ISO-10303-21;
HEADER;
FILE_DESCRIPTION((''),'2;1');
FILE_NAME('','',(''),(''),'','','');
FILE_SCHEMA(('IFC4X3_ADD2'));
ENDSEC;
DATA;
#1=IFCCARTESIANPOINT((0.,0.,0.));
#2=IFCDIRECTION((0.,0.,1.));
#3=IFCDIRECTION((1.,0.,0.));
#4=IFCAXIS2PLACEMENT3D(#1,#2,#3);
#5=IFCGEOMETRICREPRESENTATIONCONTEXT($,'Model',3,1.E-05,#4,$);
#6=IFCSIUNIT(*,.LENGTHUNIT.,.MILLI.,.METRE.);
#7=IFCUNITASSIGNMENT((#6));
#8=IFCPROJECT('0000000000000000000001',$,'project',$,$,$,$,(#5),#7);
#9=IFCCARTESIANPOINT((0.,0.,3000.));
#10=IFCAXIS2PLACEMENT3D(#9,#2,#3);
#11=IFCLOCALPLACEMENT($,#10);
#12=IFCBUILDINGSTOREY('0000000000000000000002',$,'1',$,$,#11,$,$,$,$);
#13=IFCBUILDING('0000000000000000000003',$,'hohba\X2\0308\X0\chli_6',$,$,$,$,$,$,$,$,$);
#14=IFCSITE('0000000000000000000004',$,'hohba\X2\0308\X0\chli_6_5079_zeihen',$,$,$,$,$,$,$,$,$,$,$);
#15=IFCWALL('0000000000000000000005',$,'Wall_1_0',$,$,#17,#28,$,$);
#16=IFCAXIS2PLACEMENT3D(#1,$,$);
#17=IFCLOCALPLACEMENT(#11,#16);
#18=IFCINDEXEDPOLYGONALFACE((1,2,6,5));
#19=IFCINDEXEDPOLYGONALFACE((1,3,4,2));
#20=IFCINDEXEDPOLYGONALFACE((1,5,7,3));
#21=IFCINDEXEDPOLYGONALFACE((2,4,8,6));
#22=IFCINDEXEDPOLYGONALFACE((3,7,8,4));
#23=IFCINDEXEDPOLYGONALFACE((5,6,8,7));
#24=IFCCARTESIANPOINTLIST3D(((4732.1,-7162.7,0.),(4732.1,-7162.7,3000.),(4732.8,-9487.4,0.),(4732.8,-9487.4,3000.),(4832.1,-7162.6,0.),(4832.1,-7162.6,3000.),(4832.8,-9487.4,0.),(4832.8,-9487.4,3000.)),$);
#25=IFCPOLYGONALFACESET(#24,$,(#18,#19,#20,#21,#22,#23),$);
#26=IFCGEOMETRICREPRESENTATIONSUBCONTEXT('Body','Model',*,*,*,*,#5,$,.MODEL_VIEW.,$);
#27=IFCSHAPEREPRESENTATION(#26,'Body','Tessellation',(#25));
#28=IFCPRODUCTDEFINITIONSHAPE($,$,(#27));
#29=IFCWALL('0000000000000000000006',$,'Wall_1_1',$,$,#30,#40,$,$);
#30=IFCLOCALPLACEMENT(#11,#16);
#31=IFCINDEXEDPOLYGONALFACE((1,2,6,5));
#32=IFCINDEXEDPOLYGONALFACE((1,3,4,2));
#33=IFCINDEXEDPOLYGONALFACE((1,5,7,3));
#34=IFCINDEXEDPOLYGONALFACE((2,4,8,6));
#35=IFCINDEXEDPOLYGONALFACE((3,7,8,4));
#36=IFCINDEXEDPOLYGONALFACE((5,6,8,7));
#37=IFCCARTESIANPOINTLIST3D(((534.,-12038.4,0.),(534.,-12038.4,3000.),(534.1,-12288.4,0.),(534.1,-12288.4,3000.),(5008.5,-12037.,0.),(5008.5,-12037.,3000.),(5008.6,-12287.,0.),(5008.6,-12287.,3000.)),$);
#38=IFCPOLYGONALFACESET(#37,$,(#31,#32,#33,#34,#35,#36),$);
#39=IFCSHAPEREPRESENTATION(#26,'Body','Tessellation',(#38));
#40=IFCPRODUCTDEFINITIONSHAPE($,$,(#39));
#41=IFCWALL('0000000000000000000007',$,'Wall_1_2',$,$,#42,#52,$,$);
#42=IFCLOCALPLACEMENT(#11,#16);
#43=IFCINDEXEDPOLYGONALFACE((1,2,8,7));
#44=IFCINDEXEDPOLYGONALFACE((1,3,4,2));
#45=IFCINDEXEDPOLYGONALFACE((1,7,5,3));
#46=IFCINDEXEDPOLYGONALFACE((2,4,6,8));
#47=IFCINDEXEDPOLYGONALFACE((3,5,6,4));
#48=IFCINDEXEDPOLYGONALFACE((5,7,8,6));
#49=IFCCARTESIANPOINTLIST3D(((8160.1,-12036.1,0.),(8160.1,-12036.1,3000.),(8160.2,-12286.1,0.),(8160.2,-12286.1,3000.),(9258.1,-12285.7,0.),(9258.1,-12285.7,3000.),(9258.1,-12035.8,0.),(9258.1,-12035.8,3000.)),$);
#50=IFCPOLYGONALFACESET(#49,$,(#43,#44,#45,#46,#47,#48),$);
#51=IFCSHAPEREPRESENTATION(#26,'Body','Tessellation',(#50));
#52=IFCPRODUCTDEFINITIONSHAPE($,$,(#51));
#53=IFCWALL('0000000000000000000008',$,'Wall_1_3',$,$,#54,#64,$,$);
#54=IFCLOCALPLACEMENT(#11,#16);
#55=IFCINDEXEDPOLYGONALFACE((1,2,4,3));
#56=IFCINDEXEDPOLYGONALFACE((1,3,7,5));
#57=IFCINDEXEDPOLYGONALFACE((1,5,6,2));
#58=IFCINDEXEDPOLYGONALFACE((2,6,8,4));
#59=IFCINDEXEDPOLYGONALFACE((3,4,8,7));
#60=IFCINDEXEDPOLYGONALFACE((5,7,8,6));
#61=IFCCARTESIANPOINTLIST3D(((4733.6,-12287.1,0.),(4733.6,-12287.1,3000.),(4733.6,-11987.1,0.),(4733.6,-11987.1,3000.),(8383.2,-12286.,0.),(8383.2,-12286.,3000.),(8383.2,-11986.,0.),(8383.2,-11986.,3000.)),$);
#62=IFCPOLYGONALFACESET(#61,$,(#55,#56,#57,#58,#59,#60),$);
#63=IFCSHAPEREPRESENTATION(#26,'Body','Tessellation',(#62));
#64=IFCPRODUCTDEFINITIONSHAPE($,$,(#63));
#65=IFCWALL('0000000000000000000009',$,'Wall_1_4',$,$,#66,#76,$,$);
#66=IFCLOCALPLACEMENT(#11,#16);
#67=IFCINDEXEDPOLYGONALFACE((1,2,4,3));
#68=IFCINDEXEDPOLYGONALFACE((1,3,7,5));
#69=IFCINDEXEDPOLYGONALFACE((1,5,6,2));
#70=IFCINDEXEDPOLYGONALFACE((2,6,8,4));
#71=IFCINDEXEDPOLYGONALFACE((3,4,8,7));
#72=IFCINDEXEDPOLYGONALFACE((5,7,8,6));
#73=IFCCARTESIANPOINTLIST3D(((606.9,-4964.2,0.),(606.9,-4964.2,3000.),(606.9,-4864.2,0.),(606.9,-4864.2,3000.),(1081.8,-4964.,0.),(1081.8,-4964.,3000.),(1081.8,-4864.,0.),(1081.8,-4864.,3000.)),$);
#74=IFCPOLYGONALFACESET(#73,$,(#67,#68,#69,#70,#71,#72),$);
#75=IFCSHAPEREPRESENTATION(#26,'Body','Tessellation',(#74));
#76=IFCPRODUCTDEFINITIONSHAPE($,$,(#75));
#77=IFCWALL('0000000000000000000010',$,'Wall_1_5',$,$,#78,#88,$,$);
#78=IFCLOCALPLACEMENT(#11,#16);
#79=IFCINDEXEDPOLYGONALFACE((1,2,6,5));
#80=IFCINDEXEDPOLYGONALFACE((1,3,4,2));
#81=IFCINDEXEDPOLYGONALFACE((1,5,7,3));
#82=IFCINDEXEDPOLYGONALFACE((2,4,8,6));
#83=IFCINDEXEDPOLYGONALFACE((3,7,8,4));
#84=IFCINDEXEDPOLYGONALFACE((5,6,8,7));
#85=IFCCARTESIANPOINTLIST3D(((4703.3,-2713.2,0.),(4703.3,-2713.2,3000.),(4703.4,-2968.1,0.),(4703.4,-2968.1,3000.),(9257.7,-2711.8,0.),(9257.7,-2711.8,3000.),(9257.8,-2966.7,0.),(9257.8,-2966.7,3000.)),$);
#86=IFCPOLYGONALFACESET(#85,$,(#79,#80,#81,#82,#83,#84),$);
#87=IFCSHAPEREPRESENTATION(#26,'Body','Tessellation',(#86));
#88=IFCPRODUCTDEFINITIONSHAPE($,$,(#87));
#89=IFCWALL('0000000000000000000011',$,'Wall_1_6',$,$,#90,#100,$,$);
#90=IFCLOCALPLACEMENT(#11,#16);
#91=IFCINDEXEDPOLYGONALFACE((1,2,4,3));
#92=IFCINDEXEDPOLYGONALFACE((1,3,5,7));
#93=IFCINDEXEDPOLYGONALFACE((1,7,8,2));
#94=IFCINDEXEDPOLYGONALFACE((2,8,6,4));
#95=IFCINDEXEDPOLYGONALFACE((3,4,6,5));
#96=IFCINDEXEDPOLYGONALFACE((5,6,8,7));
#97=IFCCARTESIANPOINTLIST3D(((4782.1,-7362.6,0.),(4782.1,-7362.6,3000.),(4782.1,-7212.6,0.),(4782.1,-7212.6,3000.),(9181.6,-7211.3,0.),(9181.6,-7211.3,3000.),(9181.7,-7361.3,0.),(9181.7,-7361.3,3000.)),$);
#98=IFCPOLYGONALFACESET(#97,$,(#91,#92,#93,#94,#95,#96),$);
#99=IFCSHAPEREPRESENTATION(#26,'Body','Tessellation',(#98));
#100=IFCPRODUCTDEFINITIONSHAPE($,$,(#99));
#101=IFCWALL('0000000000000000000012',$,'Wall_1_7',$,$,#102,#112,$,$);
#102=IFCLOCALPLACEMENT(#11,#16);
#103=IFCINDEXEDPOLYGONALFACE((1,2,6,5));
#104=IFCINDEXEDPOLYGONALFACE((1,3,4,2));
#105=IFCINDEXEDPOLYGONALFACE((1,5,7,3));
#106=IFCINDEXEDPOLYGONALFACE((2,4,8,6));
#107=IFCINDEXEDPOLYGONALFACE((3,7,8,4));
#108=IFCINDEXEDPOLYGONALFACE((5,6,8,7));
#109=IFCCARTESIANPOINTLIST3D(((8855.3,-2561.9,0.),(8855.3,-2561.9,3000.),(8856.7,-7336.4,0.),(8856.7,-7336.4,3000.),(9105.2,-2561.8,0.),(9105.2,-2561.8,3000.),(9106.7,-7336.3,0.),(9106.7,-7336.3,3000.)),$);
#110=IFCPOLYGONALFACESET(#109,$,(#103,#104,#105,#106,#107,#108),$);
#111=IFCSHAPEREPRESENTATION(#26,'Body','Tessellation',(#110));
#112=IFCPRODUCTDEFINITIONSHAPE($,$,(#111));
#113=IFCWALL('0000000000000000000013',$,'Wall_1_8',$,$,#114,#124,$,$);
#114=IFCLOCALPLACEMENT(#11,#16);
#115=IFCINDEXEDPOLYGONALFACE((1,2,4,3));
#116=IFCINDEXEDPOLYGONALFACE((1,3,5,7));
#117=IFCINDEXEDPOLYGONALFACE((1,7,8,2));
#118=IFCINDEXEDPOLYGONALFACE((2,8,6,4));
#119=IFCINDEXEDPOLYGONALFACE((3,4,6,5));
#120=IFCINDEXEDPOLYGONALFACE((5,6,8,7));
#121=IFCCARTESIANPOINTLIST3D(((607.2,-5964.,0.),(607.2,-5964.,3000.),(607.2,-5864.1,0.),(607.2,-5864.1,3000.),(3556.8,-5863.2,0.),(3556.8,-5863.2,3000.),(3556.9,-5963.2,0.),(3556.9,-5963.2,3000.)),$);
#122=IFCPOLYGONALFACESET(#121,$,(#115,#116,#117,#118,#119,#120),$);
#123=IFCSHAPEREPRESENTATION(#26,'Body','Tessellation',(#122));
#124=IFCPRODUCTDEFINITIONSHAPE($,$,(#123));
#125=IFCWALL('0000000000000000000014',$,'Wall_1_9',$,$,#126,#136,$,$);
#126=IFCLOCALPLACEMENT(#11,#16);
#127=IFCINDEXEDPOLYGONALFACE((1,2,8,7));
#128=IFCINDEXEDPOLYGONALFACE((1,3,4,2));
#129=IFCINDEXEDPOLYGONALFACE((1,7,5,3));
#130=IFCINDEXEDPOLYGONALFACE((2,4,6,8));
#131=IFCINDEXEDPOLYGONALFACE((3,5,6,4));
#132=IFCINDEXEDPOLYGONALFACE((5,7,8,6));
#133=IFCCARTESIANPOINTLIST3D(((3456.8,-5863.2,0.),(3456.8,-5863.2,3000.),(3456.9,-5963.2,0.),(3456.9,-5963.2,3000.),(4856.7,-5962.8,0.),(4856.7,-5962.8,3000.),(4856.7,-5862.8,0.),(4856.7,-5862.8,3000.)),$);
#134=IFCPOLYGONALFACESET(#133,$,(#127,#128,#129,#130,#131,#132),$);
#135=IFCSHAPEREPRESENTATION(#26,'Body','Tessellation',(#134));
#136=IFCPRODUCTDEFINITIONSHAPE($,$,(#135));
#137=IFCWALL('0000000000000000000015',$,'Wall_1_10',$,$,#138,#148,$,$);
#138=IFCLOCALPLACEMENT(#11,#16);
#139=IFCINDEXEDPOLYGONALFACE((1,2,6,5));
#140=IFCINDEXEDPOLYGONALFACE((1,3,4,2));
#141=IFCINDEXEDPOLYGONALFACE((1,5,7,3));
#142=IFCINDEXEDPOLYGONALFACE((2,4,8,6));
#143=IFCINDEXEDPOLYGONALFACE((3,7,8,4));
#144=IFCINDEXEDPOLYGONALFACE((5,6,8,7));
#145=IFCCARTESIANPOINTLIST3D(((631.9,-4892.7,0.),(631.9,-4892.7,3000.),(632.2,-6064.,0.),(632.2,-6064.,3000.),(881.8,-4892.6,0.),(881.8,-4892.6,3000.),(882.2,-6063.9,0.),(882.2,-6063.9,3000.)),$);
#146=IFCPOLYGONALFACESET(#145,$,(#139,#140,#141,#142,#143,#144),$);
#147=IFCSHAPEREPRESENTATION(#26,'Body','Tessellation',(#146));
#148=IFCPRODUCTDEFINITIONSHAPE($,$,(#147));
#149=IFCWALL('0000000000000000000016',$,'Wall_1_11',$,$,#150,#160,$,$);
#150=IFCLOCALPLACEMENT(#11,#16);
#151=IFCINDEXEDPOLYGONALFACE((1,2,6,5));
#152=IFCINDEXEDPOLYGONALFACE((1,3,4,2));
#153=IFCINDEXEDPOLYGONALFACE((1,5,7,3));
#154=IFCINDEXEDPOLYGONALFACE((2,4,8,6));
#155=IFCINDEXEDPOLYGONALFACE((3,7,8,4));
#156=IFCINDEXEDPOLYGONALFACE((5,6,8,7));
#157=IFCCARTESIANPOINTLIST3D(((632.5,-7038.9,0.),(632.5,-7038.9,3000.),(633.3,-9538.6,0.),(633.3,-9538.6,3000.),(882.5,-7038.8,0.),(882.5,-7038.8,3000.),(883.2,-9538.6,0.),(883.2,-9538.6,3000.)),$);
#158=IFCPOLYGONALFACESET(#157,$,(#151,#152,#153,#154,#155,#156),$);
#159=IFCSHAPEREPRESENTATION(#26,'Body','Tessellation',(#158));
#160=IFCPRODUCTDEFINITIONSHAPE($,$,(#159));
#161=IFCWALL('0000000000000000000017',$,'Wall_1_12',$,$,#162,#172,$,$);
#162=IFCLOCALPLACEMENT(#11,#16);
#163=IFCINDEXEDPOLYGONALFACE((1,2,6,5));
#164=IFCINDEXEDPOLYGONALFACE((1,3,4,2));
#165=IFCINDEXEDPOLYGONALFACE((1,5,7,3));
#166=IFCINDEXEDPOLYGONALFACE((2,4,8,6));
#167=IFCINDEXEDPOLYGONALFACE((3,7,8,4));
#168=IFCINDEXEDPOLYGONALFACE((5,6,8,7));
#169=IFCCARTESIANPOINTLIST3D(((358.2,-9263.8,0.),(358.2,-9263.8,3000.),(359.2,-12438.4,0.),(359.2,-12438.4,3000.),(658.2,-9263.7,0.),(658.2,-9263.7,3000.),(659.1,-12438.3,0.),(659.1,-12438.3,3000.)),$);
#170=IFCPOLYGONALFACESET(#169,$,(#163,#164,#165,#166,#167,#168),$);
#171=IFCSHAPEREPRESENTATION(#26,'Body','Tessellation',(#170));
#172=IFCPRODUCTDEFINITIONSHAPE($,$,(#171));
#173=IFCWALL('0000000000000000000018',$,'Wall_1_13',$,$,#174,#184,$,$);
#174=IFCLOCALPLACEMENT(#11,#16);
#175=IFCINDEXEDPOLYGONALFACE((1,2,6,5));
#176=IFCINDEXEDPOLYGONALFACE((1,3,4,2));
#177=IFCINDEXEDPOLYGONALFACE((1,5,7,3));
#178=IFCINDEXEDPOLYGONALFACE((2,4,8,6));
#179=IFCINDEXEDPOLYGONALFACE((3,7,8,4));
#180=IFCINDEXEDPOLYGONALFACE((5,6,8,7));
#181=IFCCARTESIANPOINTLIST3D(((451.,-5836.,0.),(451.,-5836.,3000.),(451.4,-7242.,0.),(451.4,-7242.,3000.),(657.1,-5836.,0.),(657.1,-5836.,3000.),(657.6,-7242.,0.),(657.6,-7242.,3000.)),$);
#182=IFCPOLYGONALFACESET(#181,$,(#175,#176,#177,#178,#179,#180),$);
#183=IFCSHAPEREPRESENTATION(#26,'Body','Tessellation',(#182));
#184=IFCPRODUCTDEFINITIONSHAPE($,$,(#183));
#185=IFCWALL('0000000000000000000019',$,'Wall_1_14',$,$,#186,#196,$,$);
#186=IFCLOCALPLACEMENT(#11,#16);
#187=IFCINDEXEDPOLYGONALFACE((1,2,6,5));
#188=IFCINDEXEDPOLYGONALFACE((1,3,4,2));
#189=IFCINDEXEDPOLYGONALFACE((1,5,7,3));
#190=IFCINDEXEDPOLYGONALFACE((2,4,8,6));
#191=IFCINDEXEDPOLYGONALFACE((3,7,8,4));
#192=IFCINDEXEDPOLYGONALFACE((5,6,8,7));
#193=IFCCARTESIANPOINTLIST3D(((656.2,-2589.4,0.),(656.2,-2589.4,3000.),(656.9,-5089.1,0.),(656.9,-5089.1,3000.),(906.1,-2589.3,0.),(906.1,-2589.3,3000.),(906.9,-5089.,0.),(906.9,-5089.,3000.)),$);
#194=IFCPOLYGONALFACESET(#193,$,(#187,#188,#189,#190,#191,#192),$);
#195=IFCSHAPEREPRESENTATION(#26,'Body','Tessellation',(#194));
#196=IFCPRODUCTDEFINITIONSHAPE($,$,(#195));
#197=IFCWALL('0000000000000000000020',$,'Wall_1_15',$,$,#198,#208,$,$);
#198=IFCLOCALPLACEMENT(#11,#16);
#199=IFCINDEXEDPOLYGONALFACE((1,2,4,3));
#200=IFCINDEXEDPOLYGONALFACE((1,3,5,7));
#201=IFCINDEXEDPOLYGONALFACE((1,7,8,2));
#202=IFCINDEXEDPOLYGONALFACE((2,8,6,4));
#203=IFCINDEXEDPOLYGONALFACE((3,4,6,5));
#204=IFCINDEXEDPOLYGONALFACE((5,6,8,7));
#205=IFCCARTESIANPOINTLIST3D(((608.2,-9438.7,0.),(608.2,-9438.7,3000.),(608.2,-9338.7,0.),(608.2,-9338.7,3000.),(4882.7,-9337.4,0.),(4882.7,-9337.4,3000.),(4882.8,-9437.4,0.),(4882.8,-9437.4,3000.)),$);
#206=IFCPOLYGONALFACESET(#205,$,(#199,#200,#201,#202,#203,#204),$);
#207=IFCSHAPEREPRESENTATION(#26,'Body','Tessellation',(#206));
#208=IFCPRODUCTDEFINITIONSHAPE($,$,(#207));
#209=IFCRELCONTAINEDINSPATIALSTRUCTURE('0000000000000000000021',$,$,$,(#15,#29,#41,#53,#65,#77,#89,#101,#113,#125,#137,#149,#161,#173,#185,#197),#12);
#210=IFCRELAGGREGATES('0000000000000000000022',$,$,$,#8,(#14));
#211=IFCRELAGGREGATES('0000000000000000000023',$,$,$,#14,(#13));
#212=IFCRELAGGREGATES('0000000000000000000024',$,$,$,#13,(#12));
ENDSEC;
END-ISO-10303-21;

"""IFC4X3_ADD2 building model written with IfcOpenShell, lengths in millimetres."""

from ifc_helpers import new_model, si_unit, frame, origin_with_axes, place, context, subcontext, project, spatial, indexed_curve, outline, extrude, element, save


model = new_model("IFC4X3_ADD2")

# Units and contexts
model_context = context("Model", 3, precision=1e-05, world=origin_with_axes())
body_context = subcontext(model_context, "Body", "Model", "MODEL_VIEW")
ifc_project = project(units=[si_unit("LENGTHUNIT", "METRE", prefix="MILLI")], contexts=[model_context])

# Site, building, storey
site = spatial("IfcSite", under=ifc_project, Name="hohbächli_6_5079_zeihen")
building = spatial("IfcBuilding", under=site, Name="hohbächli_6")
storey_placement = place(None, frame((0.0, 0.0, 3000.0), z_axis=(0.0, 0.0, 1.0), x_axis=(1.0, 0.0, 0.0)))
storey = spatial("IfcBuildingStorey", under=building, at=storey_placement, Name="1")

# Walls
wall_1_placement = place(storey_placement, frame((4832.8, -9487.4, 0.0), z_axis=(0.0, 0.0, 1.0), x_axis=(-0.000302, 1.0, 0.0)))
element("IfcWall", 1, at=wall_1_placement, inside=storey, Name="Wall_1_0", context=body_context, shape_type="SweptSolid", body=[
    extrude(outline(indexed_curve([(0.0, 0.0), (0.0, 100.0), (2324.7, 100.0), (2324.7, 0.0), (0.0, 0.0)], self_intersect=False)), origin_with_axes(), (0.0, 0.0, 1.0), 3000.0),
])
wall_2_placement = place(storey_placement, frame((534.1, -12288.4, 0.0), z_axis=(0.0, 0.0, 1.0), x_axis=(1.0, 0.000302, 0.0)))
element("IfcWall", 2, at=wall_2_placement, inside=storey, Name="Wall_1_1", context=body_context, shape_type="SweptSolid", body=[
    extrude(outline(indexed_curve([(0.0, 0.0), (0.0, 250.0), (4474.5, 250.0), (4474.5, 0.0), (0.0, 0.0)], self_intersect=False)), origin_with_axes(), (0.0, 0.0, 1.0), 3000.0),
])
wall_3_placement = place(storey_placement, frame((8160.2, -12286.1, 0.0), z_axis=(0.0, 0.0, 1.0), x_axis=(1.0, 0.000302, 0.0)))
element("IfcWall", 3, at=wall_3_placement, inside=storey, Name="Wall_1_2", context=body_context, shape_type="SweptSolid", body=[
    extrude(outline(indexed_curve([(0.0, 0.0), (0.0, 250.0), (1098.0, 250.0), (1098.0, 0.0), (0.0, 0.0)], self_intersect=False)), origin_with_axes(), (0.0, 0.0, 1.0), 3000.0),
])
wall_4_placement = place(storey_placement, frame((4733.6, -12287.1, 0.0), z_axis=(0.0, 0.0, 1.0), x_axis=(1.0, 0.000302, 0.0)))
element("IfcWall", 4, at=wall_4_placement, inside=storey, Name="Wall_1_3", context=body_context, shape_type="SweptSolid", body=[
    extrude(outline(indexed_curve([(0.0, 0.0), (0.0, 300.0), (3649.6, 300.0), (3649.6, 0.0), (0.0, 0.0)], self_intersect=False)), origin_with_axes(), (0.0, 0.0, 1.0), 3000.0),
])
wall_5_placement = place(storey_placement, frame((606.9, -4964.2, 0.0), z_axis=(0.0, 0.0, 1.0), x_axis=(1.0, 0.000302, 0.0)))
element("IfcWall", 5, at=wall_5_placement, inside=storey, Name="Wall_1_4", context=body_context, shape_type="SweptSolid", body=[
    extrude(outline(indexed_curve([(0.0, 0.0), (0.0, 100.0), (474.9, 100.0), (474.9, 0.0), (0.0, 0.0)], self_intersect=False)), origin_with_axes(), (0.0, 0.0, 1.0), 3000.0),
])
wall_6_placement = place(storey_placement, frame((9257.7, -2711.8, 0.0), z_axis=(0.0, 0.0, 1.0), x_axis=(-1.0, -0.000302, 0.0)))
element("IfcWall", 6, at=wall_6_placement, inside=storey, Name="Wall_1_5", context=body_context, shape_type="SweptSolid", body=[
    extrude(outline(indexed_curve([(0.0, 0.0), (0.0, 254.9), (4554.5, 254.9), (4554.5, 0.0), (0.0, 0.0)], self_intersect=False)), origin_with_axes(), (0.0, 0.0, 1.0), 3000.0),
])
wall_7_placement = place(storey_placement, frame((9181.6, -7211.3, 0.0), z_axis=(0.0, 0.0, 1.0), x_axis=(-1.0, -0.000302, 0.0)))
element("IfcWall", 7, at=wall_7_placement, inside=storey, Name="Wall_1_6", context=body_context, shape_type="SweptSolid", body=[
    extrude(outline(indexed_curve([(0.0, 0.0), (0.0, 150.0), (4399.5, 150.0), (4399.5, 0.0), (0.0, 0.0)], self_intersect=False)), origin_with_axes(), (0.0, 0.0, 1.0), 3000.0),
])
wall_8_placement = place(storey_placement, frame((9106.7, -7336.3, 0.0), z_axis=(0.0, 0.0, 1.0), x_axis=(-0.000302, 1.0, 0.0)))
element("IfcWall", 8, at=wall_8_placement, inside=storey, Name="Wall_1_7", context=body_context, shape_type="SweptSolid", body=[
    extrude(outline(indexed_curve([(0.0, 0.0), (0.0, 250.0), (4774.5, 250.0), (4774.5, 0.0), (0.0, 0.0)], self_intersect=False)), origin_with_axes(), (0.0, 0.0, 1.0), 3000.0),
])
wall_9_placement = place(storey_placement, frame((607.2, -5964.0, 0.0), z_axis=(0.0, 0.0, 1.0), x_axis=(1.0, 0.000302, 0.0)))
element("IfcWall", 9, at=wall_9_placement, inside=storey, Name="Wall_1_8", context=body_context, shape_type="SweptSolid", body=[
    extrude(outline(indexed_curve([(0.0, 0.0), (0.0, 100.0), (2949.7, 100.0), (2949.7, 0.0), (0.0, 0.0)], self_intersect=False)), origin_with_axes(), (0.0, 0.0, 1.0), 3000.0),
])
wall_10_placement = place(storey_placement, frame((3456.9, -5963.2, 0.0), z_axis=(0.0, 0.0, 1.0), x_axis=(1.0, 0.000302, 0.0)))
element("IfcWall", 10, at=wall_10_placement, inside=storey, Name="Wall_1_9", context=body_context, shape_type="SweptSolid", body=[
    extrude(outline(indexed_curve([(0.0, 0.0), (0.0, 100.0), (1399.8, 100.0), (1399.8, 0.0), (0.0, 0.0)], self_intersect=False)), origin_with_axes(), (0.0, 0.0, 1.0), 3000.0),
])
wall_11_placement = place(storey_placement, frame((631.9, -4892.7, 0.0), z_axis=(0.0, 0.0, 1.0), x_axis=(0.000302, -1.0, 0.0)))
element("IfcWall", 11, at=wall_11_placement, inside=storey, Name="Wall_1_10", context=body_context, shape_type="SweptSolid", body=[
    extrude(outline(indexed_curve([(0.0, 0.0), (0.0, 250.0), (1171.3, 250.0), (1171.3, 0.0), (0.0, 0.0)], self_intersect=False)), origin_with_axes(), (0.0, 0.0, 1.0), 3000.0),
])
wall_12_placement = place(storey_placement, frame((632.5, -7038.9, 0.0), z_axis=(0.0, 0.0, 1.0), x_axis=(0.000302, -1.0, 0.0)))
element("IfcWall", 12, at=wall_12_placement, inside=storey, Name="Wall_1_11", context=body_context, shape_type="SweptSolid", body=[
    extrude(outline(indexed_curve([(0.0, 0.0), (0.0, 250.0), (2499.7, 250.0), (2499.7, 0.0), (0.0, 0.0)], self_intersect=False)), origin_with_axes(), (0.0, 0.0, 1.0), 3000.0),
])
wall_13_placement = place(storey_placement, frame((659.1, -12438.3, 0.0), z_axis=(0.0, 0.0, 1.0), x_axis=(-0.000302, 1.0, 0.0)))
element("IfcWall", 13, at=wall_13_placement, inside=storey, Name="Wall_1_12", context=body_context, shape_type="SweptSolid", body=[
    extrude(outline(indexed_curve([(0.0, 0.0), (0.0, 300.0), (3174.7, 300.0), (3174.7, 0.0), (0.0, 0.0)], self_intersect=False)), origin_with_axes(), (0.0, 0.0, 1.0), 3000.0),
])
wall_14_placement = place(storey_placement, frame((657.6, -7242.0, 0.0), z_axis=(0.0, 0.0, 1.0), x_axis=(-0.000302, 1.0, 0.0)))
element("IfcWall", 14, at=wall_14_placement, inside=storey, Name="Wall_1_13", context=body_context, shape_type="SweptSolid", body=[
    extrude(outline(indexed_curve([(0.0, 0.0), (0.0, 206.1), (1406.0, 206.1), (1406.0, 0.0), (0.0, 0.0)], self_intersect=False)), origin_with_axes(), (0.0, 0.0, 1.0), 3000.0),
])
wall_15_placement = place(storey_placement, frame((656.2, -2589.4, 0.0), z_axis=(0.0, 0.0, 1.0), x_axis=(0.000302, -1.0, 0.0)))
element("IfcWall", 15, at=wall_15_placement, inside=storey, Name="Wall_1_14", context=body_context, shape_type="SweptSolid", body=[
    extrude(outline(indexed_curve([(0.0, 0.0), (0.0, 250.0), (2499.7, 250.0), (2499.7, 0.0), (0.0, 0.0)], self_intersect=False)), origin_with_axes(), (0.0, 0.0, 1.0), 3000.0),
])
wall_16_placement = place(storey_placement, frame((608.2, -9438.7, 0.0), z_axis=(0.0, 0.0, 1.0), x_axis=(1.0, 0.000302, 0.0)))
element("IfcWall", 16, at=wall_16_placement, inside=storey, Name="Wall_1_15", context=body_context, shape_type="SweptSolid", body=[
    extrude(outline(indexed_curve([(0.0, 0.0), (0.0, 100.0), (4274.5, 100.0), (4274.5, 0.0), (0.0, 0.0)], self_intersect=False)), origin_with_axes(), (0.0, 0.0, 1.0), 3000.0),
])

save(model, "model.ifc")
